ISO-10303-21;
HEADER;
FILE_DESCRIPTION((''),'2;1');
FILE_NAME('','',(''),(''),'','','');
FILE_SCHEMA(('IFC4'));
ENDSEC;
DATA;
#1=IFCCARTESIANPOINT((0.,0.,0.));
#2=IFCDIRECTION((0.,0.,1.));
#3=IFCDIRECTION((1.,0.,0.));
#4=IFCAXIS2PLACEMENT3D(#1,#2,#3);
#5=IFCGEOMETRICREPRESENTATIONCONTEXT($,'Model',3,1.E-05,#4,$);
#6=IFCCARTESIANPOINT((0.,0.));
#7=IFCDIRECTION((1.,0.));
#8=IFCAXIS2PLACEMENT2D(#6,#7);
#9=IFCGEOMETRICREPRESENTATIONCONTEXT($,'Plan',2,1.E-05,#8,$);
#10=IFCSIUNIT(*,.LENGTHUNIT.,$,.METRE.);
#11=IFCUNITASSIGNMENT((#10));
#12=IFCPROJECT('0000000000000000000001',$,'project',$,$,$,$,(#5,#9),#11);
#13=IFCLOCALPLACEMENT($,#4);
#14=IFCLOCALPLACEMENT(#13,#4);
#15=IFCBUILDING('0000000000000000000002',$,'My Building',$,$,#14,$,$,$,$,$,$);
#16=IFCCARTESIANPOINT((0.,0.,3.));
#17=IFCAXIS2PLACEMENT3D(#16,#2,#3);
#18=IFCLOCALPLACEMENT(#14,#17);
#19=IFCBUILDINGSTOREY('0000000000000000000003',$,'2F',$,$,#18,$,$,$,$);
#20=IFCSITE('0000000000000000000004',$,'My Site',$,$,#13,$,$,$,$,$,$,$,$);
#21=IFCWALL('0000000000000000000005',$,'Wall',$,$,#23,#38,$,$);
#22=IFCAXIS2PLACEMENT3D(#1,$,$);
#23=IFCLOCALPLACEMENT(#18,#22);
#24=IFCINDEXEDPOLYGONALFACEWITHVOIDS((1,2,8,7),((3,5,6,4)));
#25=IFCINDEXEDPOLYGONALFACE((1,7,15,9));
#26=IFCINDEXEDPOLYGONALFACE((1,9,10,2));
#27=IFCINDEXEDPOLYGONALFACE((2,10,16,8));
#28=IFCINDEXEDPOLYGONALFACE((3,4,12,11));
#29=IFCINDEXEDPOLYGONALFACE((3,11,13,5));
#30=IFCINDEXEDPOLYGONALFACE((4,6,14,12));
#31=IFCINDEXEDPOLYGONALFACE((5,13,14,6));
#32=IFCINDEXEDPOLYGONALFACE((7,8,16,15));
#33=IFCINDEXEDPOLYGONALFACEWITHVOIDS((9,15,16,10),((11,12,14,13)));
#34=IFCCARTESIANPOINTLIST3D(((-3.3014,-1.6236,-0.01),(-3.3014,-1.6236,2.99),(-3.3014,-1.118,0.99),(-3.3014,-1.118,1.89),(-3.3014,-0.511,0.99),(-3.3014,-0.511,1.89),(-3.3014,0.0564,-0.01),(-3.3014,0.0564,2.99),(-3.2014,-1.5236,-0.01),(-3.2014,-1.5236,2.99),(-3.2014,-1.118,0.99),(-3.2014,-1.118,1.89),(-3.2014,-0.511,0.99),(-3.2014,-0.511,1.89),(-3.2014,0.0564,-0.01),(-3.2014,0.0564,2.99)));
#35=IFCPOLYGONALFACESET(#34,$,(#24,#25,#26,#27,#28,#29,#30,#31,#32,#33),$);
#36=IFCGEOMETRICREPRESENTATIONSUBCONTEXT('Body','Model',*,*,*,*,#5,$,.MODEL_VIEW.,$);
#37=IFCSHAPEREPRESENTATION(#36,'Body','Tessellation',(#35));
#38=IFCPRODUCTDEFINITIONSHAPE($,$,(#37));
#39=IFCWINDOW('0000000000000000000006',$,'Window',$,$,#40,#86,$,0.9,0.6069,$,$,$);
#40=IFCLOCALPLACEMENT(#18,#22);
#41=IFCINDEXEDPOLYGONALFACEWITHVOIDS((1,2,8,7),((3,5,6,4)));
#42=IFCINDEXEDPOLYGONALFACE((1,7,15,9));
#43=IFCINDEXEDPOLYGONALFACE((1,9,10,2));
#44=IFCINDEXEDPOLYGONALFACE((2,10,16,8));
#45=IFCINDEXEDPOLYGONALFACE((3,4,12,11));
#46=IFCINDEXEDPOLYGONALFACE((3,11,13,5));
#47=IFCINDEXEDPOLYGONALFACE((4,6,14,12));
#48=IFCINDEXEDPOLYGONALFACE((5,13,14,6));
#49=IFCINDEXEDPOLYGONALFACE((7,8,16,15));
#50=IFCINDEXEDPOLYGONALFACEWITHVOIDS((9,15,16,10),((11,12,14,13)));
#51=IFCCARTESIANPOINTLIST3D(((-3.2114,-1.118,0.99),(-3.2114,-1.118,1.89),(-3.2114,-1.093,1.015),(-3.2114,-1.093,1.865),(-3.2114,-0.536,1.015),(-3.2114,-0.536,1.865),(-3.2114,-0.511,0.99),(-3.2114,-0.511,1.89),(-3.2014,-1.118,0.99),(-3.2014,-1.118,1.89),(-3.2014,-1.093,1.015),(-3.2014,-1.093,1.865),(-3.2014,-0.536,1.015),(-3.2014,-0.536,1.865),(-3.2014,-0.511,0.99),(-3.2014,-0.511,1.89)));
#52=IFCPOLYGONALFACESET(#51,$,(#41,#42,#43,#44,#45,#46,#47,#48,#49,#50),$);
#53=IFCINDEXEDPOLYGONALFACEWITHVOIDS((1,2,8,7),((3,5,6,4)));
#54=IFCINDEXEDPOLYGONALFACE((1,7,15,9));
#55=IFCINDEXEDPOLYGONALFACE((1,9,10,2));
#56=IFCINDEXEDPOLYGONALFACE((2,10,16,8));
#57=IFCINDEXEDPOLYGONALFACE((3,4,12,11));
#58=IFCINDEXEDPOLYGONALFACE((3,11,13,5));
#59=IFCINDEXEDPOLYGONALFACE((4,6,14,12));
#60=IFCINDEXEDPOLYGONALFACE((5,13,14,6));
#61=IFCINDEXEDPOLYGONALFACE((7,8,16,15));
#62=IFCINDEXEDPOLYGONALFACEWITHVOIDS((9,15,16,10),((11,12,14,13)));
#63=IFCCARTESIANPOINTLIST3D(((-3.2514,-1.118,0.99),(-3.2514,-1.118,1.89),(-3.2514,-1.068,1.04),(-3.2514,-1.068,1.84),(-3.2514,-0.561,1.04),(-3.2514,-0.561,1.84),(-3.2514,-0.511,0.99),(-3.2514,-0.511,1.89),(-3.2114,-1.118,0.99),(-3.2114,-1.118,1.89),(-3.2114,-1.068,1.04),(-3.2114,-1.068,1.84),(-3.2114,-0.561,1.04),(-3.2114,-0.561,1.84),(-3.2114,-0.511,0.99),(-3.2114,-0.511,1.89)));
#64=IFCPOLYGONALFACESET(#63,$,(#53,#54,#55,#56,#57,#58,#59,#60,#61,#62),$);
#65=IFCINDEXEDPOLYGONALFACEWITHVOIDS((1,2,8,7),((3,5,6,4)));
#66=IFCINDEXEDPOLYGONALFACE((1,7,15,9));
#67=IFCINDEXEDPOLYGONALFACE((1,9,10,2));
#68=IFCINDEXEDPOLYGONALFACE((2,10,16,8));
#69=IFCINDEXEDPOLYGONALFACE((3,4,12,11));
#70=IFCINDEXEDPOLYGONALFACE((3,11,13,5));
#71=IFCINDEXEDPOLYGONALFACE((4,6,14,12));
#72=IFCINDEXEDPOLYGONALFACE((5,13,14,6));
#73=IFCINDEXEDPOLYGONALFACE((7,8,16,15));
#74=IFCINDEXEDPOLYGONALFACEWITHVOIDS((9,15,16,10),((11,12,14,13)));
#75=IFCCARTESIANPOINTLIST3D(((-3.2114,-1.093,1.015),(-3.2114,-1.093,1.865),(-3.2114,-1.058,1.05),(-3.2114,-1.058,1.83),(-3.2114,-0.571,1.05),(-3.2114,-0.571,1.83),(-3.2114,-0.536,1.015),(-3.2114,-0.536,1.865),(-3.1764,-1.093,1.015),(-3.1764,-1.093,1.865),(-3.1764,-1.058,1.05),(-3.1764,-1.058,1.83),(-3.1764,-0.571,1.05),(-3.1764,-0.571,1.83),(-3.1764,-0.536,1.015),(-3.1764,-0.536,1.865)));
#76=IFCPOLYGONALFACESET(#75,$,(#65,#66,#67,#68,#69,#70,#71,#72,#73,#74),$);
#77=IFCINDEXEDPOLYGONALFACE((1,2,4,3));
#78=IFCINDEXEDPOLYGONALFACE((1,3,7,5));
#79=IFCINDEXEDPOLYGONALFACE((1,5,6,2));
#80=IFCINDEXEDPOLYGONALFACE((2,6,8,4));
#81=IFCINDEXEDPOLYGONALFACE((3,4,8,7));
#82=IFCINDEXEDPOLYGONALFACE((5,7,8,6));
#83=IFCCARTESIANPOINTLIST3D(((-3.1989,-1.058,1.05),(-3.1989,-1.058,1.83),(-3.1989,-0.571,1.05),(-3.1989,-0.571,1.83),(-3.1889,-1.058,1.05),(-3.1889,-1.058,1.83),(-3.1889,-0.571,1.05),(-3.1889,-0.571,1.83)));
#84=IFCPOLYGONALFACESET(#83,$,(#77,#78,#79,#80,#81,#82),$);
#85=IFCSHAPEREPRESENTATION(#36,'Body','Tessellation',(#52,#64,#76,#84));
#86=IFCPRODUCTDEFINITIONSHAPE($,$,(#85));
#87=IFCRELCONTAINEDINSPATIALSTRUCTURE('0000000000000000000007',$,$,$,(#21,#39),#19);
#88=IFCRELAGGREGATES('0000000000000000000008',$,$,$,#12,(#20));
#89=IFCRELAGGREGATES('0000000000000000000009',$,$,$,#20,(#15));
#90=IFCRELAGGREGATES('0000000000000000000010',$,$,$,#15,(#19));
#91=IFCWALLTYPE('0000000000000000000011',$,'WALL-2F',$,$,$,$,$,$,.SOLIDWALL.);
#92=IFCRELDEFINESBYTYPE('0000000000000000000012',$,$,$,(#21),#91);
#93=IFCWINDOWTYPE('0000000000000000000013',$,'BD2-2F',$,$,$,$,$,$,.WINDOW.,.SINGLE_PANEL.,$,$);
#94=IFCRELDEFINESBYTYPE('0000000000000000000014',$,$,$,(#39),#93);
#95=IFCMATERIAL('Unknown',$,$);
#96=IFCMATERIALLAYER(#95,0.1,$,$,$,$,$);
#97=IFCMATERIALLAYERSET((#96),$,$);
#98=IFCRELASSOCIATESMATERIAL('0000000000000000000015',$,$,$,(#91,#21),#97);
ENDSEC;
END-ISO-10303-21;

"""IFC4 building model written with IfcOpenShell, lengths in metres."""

from ifc_helpers import new_model, entity, si_unit, frame, origin_with_axes, origin_2d_with_axis, place, context, subcontext, project, spatial, line, indexed_curve, outline, extrude, shape, source, transform, mapped, material, layer, layer_set, layer_usage, type_object, type_shapes, element, fill, save


model = new_model("IFC4")

# Units and contexts
model_context = context("Model", 3, precision=1e-05, world=origin_with_axes())
plan_context = context("Plan", 2, precision=1e-05, world=origin_2d_with_axis())
body_context_1 = subcontext(model_context, "Body", "Model", "MODEL_VIEW")
body_context_2 = subcontext(plan_context, "Body", "Plan", "PLAN_VIEW")
ifc_project = project(units=[si_unit("LENGTHUNIT", "METRE")], contexts=[model_context, plan_context])

# Site, building, storey
site_placement = place(None, origin_with_axes())
site = spatial("IfcSite", under=ifc_project, at=site_placement, Name="My Site")
building_placement = place(site_placement, origin_with_axes())
building = spatial("IfcBuilding", under=site, at=building_placement, Name="My Building")
storey_placement = place(building_placement, frame((0.0, 0.0, 3.0), z_axis=(0.0, 0.0, 1.0), x_axis=(1.0, 0.0, 0.0)))
storey = spatial("IfcBuildingStorey", under=building, at=storey_placement, Name="2F")

# Shared definitions
ifc_material_1 = material(Name="Unknown")

# Shared definitions
ifc_layer_1 = layer(ifc_material_1, 0.1)
ifc_layer_set_1 = layer_set([ifc_layer_1])
wall_type_1 = type_object("IfcWallType", Name="WALL-2F", PredefinedType="SOLIDWALL", material=ifc_layer_set_1)

# Wall, opening, window
shared_shape_1 = source(origin_with_axes(), body_context_1, "Body", "SweptSolid", [
    extrude(outline(indexed_curve([(0.0, 0.0), (0.6069, 0.0), (0.6069, 0.9), (0.0, 0.9)], segments=[line(1, 2, 3, 4, 1)])), frame((0.0, -0.6, 0.0), z_axis=(0.0, -1.0, 0.0), x_axis=(1.0, 0.0, 0.0)), (0.0, 0.0, -1.0), 1.2),
])
window_type_1 = type_object("IfcWindowType", Name="BD2-2F", PartitioningType="SINGLE_PANEL", PredefinedType="WINDOW")
shared_shape_2 = source(origin_with_axes(), body_context_1, "Body", "SweptSolid", [
    extrude(outline(indexed_curve([(0.0, 0.0), (0.6069, 0.0), (0.6069, 0.9), (0.0, 0.9)], segments=[line(1, 2, 3, 4, 1)]), holes=[indexed_curve([(0.025, 0.025), (0.5819, 0.025), (0.5819, 0.875), (0.025, 0.875)], segments=[line(1, 2, 3, 4, 1)])]), frame((0.0, 0.09, 0.0), z_axis=(0.0, -1.0, 0.0), x_axis=(1.0, 0.0, 0.0)), (0.0, 0.0, -1.0), 0.01),
    extrude(outline(indexed_curve([(0.0, 0.0), (0.6069, 0.0), (0.6069, 0.9), (0.0, 0.9)], segments=[line(1, 2, 3, 4, 1)]), holes=[indexed_curve([(0.05, 0.05), (0.5569, 0.05), (0.5569, 0.85), (0.05, 0.85)], segments=[line(1, 2, 3, 4, 1)])]), frame((0.0, 0.05, 0.0), z_axis=(0.0, -1.0, 0.0), x_axis=(1.0, 0.0, 0.0)), (0.0, 0.0, -1.0), 0.04),
    extrude(outline(indexed_curve([(0.0, 0.0), (0.5569, 0.0), (0.5569, 0.85), (0.0, 0.85)], segments=[line(1, 2, 3, 4, 1)]), holes=[indexed_curve([(0.035, 0.035), (0.5219, 0.035), (0.5219, 0.815), (0.035, 0.815)], segments=[line(1, 2, 3, 4, 1)])]), frame((0.025, 0.09, 0.025), z_axis=(0.0, -1.0, 0.0), x_axis=(1.0, 0.0, 0.0)), (0.0, 0.0, -1.0), 0.035),
    extrude(outline(indexed_curve([(0.035, 0.035), (0.5219, 0.035), (0.5219, 0.815), (0.035, 0.815)], segments=[line(1, 2, 3, 4, 1)])), frame((0.025, 0.1025, 0.025), z_axis=(0.0, -1.0, 0.0), x_axis=(1.0, 0.0, 0.0)), (0.0, 0.0, -1.0), 0.01),
])
shared_shape_3 = source(origin_with_axes(), body_context_2, "Body", "Curve2D", [
    entity("IfcIndexedPolyCurve", entity("IfcCartesianPointList2D", [[0.05, 0.05], [0.5569, 0.05]])),
    entity("IfcIndexedPolyCurve", entity("IfcCartesianPointList2D", [[0.0, 0.1], [0.025, 0.1], [0.025, 0.09], [0.05, 0.09], [0.05, 0.05], [0.0, 0.05]]), [entity("IfcLineIndex", [1, 2, 3, 4, 5, 6, 1])]),
    entity("IfcIndexedPolyCurve", entity("IfcCartesianPointList2D", [[0.6069, 0.1], [0.5819, 0.1], [0.5819, 0.09], [0.5569, 0.09], [0.5569, 0.05], [0.6069, 0.05]]), [entity("IfcLineIndex", [1, 2, 3, 4, 5, 6, 1])]),
    entity("IfcIndexedPolyCurve", entity("IfcCartesianPointList2D", [[0.025, 0.09], [0.06, 0.09], [0.06, 0.125], [0.025, 0.125]]), [entity("IfcLineIndex", [1, 2, 3, 4, 1])]),
    entity("IfcIndexedPolyCurve", entity("IfcCartesianPointList2D", [[0.5819, 0.09], [0.5469, 0.09], [0.5469, 0.125], [0.5819, 0.125]]), [entity("IfcLineIndex", [1, 2, 3, 4, 1])]),
    entity("IfcIndexedPolyCurve", entity("IfcCartesianPointList2D", [[0.06, 0.09], [0.5469, 0.09]])),
    entity("IfcIndexedPolyCurve", entity("IfcCartesianPointList2D", [[0.06, 0.125], [0.5469, 0.125]])),
    entity("IfcIndexedPolyCurve", entity("IfcCartesianPointList2D", [[0.06, 0.1075], [0.5469, 0.1075]])),
])
type_shapes(window_type_1, [shared_shape_2, shared_shape_3])
ifc_layer_usage_1 = layer_usage(ifc_layer_set_1, "AXIS2", "POSITIVE", 0.0)
wall_1_placement = place(storey_placement, frame((-3.3014, 0.0564, -0.01), z_axis=(0.0, 0.0, 1.0), x_axis=(0.0, -1.0, 0.0)))
wall_1 = element("IfcWall", 1, at=wall_1_placement, inside=storey, type_object=wall_type_1, material=ifc_layer_usage_1, Name="Wall", context=body_context_1, shape_type="SweptSolid", body=[
    extrude(outline(indexed_curve([(0.0, 0.0), (0.0, 0.1), (1.58, 0.1), (1.68, 0.0)], segments=[line(1, 2, 3, 4, 1)])), origin_with_axes(), (0.0, 0.0, 1.0), 3.0),
])
opening_1_placement = place(wall_1_placement, frame((0.5674, 0.0, 1.0), z_axis=(0.0, 0.0, 1.0), x_axis=(1.0, 0.0, 0.0)))
opening_1 = element("IfcOpeningElement", 2, at=opening_1_placement, cuts=wall_1, PredefinedType="OPENING", context=body_context_1, shape_type="MappedRepresentation", body=[
    mapped(shared_shape_1, transform((0.0, 0.0, 0.0), x_axis=(1.0, 0.0, 0.0), y_axis=(0.0, 1.0, 0.0), z_axis=(0.0, 0.0, 1.0), scale=1.0)),
])
window_1_placement = place(opening_1_placement, frame((0.0, 0.0, 0.0), z_axis=(0.0, 0.0, 1.0), x_axis=(1.0, 0.0, 0.0)))
window_1 = element("IfcWindow", 3, at=window_1_placement, inside=storey, type_object=window_type_1, Name="Window", OverallHeight=0.9, OverallWidth=0.6069, shapes=[
    shape(body_context_1, "Body", "MappedRepresentation", [mapped(shared_shape_2, transform((0.0, 0.0, 0.0), x_axis=(1.0, 0.0, 0.0), y_axis=(0.0, 1.0, 0.0), z_axis=(0.0, 0.0, 1.0), scale=1.0))]),
    shape(body_context_2, "Body", "MappedRepresentation", [mapped(shared_shape_3, transform((0.0, 0.0, 0.0), x_axis=(1.0, 0.0, 0.0), y_axis=(0.0, 1.0, 0.0), z_axis=(0.0, 0.0, 1.0), scale=1.0))]),
])
fill(opening_1, window_1)

save(model, "model.ifc")
